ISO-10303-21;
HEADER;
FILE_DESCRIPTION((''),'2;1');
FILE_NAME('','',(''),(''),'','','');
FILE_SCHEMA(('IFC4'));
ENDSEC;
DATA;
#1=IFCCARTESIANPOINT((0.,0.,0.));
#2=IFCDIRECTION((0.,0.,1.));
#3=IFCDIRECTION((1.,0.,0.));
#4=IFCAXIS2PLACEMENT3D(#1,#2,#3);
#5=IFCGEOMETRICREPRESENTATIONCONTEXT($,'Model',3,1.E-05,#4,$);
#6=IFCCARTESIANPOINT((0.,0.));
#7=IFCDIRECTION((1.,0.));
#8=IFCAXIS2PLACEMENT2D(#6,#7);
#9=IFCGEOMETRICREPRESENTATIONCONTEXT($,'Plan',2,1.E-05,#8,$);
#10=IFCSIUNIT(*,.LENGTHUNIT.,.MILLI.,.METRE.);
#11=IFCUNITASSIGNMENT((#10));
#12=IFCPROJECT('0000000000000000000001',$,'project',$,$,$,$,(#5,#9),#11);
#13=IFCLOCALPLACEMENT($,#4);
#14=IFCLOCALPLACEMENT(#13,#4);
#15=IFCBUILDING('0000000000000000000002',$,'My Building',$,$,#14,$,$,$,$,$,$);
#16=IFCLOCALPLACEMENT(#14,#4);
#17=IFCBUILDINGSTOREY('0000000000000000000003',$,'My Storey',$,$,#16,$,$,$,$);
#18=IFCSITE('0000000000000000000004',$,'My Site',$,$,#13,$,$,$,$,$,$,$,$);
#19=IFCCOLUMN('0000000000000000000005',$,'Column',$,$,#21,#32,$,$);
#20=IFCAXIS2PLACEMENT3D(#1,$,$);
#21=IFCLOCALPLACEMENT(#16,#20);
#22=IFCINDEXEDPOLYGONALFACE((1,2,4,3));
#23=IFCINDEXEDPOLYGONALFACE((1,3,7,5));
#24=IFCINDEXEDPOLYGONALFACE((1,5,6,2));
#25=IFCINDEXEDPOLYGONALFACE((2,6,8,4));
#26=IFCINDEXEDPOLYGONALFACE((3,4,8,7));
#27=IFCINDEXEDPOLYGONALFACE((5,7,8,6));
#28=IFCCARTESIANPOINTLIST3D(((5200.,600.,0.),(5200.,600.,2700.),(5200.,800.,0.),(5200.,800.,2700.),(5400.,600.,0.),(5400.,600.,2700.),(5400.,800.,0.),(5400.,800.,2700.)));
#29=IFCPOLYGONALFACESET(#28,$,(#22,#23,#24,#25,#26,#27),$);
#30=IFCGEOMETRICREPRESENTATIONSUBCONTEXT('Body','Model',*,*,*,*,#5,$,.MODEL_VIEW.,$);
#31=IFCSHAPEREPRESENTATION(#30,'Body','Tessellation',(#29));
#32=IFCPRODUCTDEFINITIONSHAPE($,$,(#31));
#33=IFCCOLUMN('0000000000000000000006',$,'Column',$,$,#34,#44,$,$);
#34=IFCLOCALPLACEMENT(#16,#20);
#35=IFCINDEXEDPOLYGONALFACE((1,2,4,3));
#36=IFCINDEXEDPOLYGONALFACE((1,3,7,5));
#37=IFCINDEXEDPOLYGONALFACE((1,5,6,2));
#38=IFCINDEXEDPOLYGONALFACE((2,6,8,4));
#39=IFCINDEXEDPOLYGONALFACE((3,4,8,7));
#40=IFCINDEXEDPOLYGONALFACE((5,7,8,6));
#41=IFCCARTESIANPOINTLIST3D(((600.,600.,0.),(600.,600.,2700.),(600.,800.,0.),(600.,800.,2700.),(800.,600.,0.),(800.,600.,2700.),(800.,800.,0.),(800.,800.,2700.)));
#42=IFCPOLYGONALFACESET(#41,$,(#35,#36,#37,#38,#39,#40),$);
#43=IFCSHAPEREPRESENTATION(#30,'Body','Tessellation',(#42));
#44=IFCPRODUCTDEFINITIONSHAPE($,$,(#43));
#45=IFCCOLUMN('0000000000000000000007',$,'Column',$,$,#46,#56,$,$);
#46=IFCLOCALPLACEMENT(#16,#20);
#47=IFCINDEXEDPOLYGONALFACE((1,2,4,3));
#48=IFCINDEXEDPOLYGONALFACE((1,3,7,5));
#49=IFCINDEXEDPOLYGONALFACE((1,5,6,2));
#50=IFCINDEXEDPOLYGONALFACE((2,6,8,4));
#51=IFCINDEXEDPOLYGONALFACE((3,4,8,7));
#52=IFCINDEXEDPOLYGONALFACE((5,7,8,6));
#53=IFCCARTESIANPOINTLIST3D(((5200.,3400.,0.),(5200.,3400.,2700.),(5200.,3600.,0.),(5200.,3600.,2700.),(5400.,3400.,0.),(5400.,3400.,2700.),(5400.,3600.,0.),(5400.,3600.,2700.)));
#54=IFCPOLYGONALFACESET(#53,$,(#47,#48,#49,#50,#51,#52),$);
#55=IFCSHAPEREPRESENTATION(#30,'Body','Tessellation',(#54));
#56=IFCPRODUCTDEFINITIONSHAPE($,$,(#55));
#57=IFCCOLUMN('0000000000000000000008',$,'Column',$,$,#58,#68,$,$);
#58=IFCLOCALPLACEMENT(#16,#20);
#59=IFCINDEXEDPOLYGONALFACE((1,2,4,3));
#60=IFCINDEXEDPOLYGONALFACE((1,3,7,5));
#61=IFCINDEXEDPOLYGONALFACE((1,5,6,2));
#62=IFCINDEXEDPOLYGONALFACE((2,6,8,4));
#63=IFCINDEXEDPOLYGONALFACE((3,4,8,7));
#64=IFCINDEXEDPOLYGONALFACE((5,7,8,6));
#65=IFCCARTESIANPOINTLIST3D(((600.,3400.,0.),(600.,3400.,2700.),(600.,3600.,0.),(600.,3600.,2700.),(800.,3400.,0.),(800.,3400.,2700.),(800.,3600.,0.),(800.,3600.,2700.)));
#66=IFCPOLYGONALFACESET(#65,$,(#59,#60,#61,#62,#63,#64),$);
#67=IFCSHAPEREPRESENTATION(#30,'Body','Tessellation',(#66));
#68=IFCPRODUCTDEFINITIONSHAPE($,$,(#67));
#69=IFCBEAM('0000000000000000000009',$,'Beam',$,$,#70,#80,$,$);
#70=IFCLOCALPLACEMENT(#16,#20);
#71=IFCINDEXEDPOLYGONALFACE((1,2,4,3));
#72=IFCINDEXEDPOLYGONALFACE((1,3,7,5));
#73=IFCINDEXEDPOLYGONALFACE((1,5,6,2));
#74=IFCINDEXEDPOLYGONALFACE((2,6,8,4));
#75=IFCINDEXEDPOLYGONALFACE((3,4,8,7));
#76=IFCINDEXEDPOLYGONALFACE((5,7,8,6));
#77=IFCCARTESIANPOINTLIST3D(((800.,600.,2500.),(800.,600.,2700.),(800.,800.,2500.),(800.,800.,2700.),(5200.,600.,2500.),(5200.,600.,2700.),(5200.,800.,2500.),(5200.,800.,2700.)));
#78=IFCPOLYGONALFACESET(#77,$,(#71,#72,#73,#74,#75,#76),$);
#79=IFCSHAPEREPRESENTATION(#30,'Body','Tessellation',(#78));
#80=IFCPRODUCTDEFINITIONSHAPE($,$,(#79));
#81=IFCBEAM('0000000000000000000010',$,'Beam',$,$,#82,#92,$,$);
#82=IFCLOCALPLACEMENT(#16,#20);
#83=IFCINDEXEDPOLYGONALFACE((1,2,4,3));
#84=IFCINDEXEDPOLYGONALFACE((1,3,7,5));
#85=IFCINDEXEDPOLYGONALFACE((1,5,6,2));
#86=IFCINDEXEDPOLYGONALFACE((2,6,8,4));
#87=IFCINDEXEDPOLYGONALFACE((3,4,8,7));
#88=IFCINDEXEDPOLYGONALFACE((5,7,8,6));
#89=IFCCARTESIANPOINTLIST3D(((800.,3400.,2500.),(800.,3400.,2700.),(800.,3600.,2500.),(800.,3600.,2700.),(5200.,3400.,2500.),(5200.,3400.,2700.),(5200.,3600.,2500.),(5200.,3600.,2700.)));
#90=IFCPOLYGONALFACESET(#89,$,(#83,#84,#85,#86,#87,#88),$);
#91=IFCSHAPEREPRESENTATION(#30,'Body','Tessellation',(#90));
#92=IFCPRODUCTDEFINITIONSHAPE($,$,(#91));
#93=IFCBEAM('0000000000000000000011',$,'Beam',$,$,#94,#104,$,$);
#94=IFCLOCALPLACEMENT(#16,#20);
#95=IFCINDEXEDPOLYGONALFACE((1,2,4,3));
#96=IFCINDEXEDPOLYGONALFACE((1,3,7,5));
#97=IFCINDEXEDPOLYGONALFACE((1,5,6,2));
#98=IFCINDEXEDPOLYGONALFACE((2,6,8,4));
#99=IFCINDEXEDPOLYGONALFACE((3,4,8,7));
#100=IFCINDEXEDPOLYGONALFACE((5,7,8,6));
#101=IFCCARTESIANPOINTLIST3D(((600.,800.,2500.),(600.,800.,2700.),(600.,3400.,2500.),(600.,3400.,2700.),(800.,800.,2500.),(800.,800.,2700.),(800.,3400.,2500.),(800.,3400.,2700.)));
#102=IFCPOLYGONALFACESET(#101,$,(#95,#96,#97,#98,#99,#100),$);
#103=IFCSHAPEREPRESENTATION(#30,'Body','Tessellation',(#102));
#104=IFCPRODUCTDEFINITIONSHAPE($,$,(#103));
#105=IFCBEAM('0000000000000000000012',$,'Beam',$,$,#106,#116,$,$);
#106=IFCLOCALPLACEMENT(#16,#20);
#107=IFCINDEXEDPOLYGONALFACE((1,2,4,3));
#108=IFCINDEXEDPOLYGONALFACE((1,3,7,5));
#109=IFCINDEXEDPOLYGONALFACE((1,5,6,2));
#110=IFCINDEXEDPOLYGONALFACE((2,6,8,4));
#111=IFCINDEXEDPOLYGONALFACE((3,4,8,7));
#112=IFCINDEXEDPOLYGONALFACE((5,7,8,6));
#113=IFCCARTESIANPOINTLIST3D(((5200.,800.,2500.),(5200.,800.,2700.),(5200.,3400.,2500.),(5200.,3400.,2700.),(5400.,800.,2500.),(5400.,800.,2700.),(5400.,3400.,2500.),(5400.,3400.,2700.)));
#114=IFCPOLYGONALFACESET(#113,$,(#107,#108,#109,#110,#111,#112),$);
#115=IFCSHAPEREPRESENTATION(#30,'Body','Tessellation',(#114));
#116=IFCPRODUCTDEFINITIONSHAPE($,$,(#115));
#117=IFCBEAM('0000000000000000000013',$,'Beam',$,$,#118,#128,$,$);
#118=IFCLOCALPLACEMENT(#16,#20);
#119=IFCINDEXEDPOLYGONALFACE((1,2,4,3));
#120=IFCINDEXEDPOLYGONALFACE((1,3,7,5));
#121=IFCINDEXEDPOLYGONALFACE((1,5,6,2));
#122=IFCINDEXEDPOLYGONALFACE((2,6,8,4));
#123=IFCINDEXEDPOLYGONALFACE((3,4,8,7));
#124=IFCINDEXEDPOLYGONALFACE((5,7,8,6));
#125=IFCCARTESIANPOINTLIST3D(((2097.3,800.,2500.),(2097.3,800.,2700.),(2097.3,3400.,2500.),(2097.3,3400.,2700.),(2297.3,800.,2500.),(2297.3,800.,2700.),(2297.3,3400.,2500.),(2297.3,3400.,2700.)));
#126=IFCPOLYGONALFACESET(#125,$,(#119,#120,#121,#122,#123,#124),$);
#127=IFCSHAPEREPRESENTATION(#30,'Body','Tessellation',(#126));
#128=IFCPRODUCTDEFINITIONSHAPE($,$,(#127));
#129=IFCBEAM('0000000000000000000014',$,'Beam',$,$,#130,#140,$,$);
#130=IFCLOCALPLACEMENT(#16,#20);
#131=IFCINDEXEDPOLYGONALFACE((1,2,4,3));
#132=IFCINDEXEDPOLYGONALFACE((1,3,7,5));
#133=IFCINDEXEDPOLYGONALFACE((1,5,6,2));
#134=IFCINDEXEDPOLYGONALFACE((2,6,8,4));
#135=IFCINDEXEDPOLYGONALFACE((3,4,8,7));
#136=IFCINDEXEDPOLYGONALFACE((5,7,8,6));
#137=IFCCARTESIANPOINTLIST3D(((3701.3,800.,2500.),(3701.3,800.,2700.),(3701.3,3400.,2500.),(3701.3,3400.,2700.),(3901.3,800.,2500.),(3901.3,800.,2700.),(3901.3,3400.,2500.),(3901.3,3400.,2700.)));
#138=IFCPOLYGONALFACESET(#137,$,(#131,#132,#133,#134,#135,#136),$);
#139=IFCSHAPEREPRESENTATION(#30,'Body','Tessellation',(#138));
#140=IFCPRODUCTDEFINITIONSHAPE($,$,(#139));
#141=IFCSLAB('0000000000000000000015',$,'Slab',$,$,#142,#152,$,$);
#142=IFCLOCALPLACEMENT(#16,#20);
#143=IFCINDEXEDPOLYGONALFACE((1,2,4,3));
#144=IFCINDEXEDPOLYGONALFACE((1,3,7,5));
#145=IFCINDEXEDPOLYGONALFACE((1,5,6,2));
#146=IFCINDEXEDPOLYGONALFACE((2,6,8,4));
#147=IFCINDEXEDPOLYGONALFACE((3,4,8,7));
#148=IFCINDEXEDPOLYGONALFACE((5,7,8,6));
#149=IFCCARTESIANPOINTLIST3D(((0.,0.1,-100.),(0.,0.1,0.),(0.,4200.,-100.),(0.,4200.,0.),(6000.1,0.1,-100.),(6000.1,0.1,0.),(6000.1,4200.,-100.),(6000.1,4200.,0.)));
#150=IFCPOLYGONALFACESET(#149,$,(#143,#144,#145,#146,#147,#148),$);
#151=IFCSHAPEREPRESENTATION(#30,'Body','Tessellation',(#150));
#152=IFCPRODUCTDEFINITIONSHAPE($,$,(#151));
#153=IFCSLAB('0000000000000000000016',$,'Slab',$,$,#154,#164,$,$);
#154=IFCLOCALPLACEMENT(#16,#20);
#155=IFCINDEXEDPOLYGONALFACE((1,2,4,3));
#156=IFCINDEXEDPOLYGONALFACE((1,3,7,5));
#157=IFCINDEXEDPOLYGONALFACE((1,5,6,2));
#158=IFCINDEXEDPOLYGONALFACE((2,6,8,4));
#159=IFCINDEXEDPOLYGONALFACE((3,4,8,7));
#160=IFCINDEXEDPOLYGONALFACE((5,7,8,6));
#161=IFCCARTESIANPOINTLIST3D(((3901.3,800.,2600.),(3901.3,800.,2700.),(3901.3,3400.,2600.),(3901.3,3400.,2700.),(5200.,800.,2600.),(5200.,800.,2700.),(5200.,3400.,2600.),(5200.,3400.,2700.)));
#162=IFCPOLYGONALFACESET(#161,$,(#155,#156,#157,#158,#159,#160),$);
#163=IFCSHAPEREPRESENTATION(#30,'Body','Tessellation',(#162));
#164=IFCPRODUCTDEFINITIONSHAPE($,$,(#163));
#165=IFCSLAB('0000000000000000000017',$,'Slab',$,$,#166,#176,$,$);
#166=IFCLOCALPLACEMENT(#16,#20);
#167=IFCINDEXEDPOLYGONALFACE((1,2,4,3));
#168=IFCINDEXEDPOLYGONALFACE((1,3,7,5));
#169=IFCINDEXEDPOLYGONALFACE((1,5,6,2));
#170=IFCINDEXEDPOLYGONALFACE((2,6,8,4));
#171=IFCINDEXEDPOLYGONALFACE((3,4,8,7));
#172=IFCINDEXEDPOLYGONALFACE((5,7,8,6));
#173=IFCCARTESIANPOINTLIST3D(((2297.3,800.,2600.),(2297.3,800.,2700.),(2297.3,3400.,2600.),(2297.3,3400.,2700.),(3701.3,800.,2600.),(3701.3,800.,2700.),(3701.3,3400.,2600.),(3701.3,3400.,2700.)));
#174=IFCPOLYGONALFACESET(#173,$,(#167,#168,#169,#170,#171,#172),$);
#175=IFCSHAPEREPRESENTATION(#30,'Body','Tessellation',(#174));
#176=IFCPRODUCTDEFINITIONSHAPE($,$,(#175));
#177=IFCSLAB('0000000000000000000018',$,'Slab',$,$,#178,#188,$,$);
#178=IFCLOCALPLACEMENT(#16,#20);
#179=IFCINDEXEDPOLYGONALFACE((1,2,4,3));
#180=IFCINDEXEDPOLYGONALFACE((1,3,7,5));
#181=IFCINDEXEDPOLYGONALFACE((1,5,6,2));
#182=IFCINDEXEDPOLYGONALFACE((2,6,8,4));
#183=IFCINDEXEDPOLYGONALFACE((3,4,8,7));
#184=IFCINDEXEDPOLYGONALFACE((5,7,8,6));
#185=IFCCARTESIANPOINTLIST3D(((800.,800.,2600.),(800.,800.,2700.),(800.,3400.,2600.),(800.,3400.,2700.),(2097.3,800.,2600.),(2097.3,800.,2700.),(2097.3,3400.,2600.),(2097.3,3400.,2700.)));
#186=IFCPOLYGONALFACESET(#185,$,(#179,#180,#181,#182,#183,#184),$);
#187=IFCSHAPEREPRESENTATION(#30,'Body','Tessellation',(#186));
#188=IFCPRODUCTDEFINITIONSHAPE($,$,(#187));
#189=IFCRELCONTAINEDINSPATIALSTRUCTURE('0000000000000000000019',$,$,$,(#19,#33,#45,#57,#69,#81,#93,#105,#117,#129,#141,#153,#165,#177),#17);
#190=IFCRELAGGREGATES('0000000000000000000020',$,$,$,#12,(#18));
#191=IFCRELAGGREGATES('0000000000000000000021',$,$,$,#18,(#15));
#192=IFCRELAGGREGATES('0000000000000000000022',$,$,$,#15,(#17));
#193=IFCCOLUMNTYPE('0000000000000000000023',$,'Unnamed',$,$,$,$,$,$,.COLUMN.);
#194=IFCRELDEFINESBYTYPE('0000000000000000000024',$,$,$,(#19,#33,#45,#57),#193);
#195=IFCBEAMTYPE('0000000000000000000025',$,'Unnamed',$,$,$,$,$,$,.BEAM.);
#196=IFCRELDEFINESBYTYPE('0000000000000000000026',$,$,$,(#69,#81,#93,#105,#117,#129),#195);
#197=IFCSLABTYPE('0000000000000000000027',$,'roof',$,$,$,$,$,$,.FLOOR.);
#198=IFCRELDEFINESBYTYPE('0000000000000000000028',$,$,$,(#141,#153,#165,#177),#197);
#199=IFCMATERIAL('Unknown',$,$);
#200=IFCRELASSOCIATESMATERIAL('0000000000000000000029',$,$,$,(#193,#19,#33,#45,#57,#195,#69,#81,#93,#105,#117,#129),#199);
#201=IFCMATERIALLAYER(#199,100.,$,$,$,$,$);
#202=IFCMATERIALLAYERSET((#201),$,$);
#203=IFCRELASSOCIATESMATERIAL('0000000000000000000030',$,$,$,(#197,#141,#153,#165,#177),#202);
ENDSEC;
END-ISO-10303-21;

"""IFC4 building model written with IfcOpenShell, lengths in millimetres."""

from ifc_helpers import new_model, si_unit, frame, origin_with_axes, origin_2d_with_axis, place, context, subcontext, project, spatial, indexed_curve, rectangle, outline, extrude, material, layer, layer_set, layer_usage, material_profile, profile_set, profile_usage, type_object, element, save


model = new_model("IFC4")

# Units and contexts
model_context = context("Model", 3, precision=1e-05, world=origin_with_axes())
plan_context = context("Plan", 2, precision=1e-05, world=origin_2d_with_axis())
body_context_1 = subcontext(model_context, "Body", "Model", "MODEL_VIEW")
ifc_project = project(units=[si_unit("LENGTHUNIT", "METRE", prefix="MILLI")], contexts=[model_context, plan_context])

# Site, building, storey
site_placement = place(None, origin_with_axes())
site = spatial("IfcSite", under=ifc_project, at=site_placement, Name="My Site")
building_placement = place(site_placement, origin_with_axes())
building = spatial("IfcBuilding", under=site, at=building_placement, Name="My Building")
storey_placement = place(building_placement, origin_with_axes())
storey = spatial("IfcBuildingStorey", under=building, at=storey_placement, Name="My Storey")

# Columns
ifc_material = material(Name="Unknown")
ifc_material_profile_1 = material_profile(ifc_material, rectangle(XDim=200.0, YDim=200.0))
ifc_profile_set_1 = profile_set([ifc_material_profile_1])
ifc_profile_usage_1 = profile_usage(ifc_profile_set_1, cardinal=5)
column_type = type_object("IfcColumnType", Name="Unnamed", PredefinedType="COLUMN", material=ifc_profile_set_1)
column_1_placement = place(storey_placement, frame((5300.0, 700.0, 0.0), z_axis=(0.0, 0.0, 1.0), x_axis=(1.0, 0.0, 0.0)))
element("IfcColumn", 1, at=column_1_placement, inside=storey, type_object=column_type, material=ifc_profile_usage_1, Name="Column", context=body_context_1, shape_type="SweptSolid", body=[
    extrude(rectangle(XDim=200.0, YDim=200.0), origin_with_axes(), (0.0, 0.0, 1.0), 2700.0),
])
ifc_profile_usage_2 = profile_usage(ifc_profile_set_1, cardinal=5)
column_2_placement = place(storey_placement, frame((700.0, 700.0, 0.0), z_axis=(0.0, 0.0, 1.0), x_axis=(1.0, 0.0, 0.0)))
element("IfcColumn", 2, at=column_2_placement, inside=storey, type_object=column_type, material=ifc_profile_usage_2, Name="Column", context=body_context_1, shape_type="SweptSolid", body=[
    extrude(rectangle(XDim=200.0, YDim=200.0), origin_with_axes(), (0.0, 0.0, 1.0), 2700.0),
])
ifc_profile_usage_3 = profile_usage(ifc_profile_set_1, cardinal=5)
column_3_placement = place(storey_placement, frame((5300.0, 3500.0, 0.0), z_axis=(0.0, 0.0, 1.0), x_axis=(1.0, 0.0, 0.0)))
element("IfcColumn", 3, at=column_3_placement, inside=storey, type_object=column_type, material=ifc_profile_usage_3, Name="Column", context=body_context_1, shape_type="SweptSolid", body=[
    extrude(rectangle(XDim=200.0, YDim=200.0), origin_with_axes(), (0.0, 0.0, 1.0), 2700.0),
])
ifc_profile_usage_4 = profile_usage(ifc_profile_set_1, cardinal=5)
column_4_placement = place(storey_placement, frame((700.0, 3500.0, 0.0), z_axis=(0.0, 0.0, 1.0), x_axis=(1.0, 0.0, 0.0)))
element("IfcColumn", 4, at=column_4_placement, inside=storey, type_object=column_type, material=ifc_profile_usage_4, Name="Column", context=body_context_1, shape_type="SweptSolid", body=[
    extrude(rectangle(XDim=200.0, YDim=200.0), origin_with_axes(), (0.0, 0.0, 1.0), 2700.0),
])

# Beams
ifc_material_profile_2 = material_profile(ifc_material, rectangle(XDim=200.0, YDim=200.0))
ifc_profile_set_2 = profile_set([ifc_material_profile_2])
ifc_profile_usage_5 = profile_usage(ifc_profile_set_2, cardinal=5)
beam_type = type_object("IfcBeamType", Name="Unnamed", PredefinedType="BEAM", material=ifc_profile_set_2)
beam_1_placement = place(storey_placement, frame((800.0, 700.0, 2600.0), z_axis=(1.0, 0.0, 0.0), x_axis=(0.0, 1.0, 0.0)))
element("IfcBeam", 5, at=beam_1_placement, inside=storey, type_object=beam_type, material=ifc_profile_usage_5, Name="Beam", context=body_context_1, shape_type="SweptSolid", body=[
    extrude(rectangle(XDim=200.0, YDim=200.0), origin_with_axes(), (0.0, 0.0, 1.0), 4400.0),
])
ifc_profile_usage_6 = profile_usage(ifc_profile_set_2, cardinal=5)
beam_2_placement = place(storey_placement, frame((800.0, 3500.0, 2600.0), z_axis=(1.0, 0.0, 0.0), x_axis=(0.0, 1.0, 0.0)))
element("IfcBeam", 6, at=beam_2_placement, inside=storey, type_object=beam_type, material=ifc_profile_usage_6, Name="Beam", context=body_context_1, shape_type="SweptSolid", body=[
    extrude(rectangle(XDim=200.0, YDim=200.0), origin_with_axes(), (0.0, 0.0, 1.0), 4400.0),
])
ifc_profile_usage_7 = profile_usage(ifc_profile_set_2, cardinal=5)
beam_3_placement = place(storey_placement, frame((700.0, 3400.0, 2600.0), z_axis=(0.0, -1.0, 0.0), x_axis=(1.0, 0.0, 0.0)))
element("IfcBeam", 7, at=beam_3_placement, inside=storey, type_object=beam_type, material=ifc_profile_usage_7, Name="Beam", context=body_context_1, shape_type="SweptSolid", body=[
    extrude(rectangle(XDim=200.0, YDim=200.0), origin_with_axes(), (0.0, 0.0, 1.0), 2600.0),
])
ifc_profile_usage_8 = profile_usage(ifc_profile_set_2, cardinal=5)
beam_4_placement = place(storey_placement, frame((5300.0, 3400.0, 2600.0), z_axis=(0.0, -1.0, 0.0), x_axis=(1.0, 0.0, 0.0)))
element("IfcBeam", 8, at=beam_4_placement, inside=storey, type_object=beam_type, material=ifc_profile_usage_8, Name="Beam", context=body_context_1, shape_type="SweptSolid", body=[
    extrude(rectangle(XDim=200.0, YDim=200.0), origin_with_axes(), (0.0, 0.0, 1.0), 2600.0),
])
ifc_profile_usage_9 = profile_usage(ifc_profile_set_2, cardinal=5)
beam_5_placement = place(storey_placement, frame((2197.3, 3400.0, 2600.0), z_axis=(0.0, -1.0, 0.0), x_axis=(1.0, 0.0, 0.0)))
element("IfcBeam", 9, at=beam_5_placement, inside=storey, type_object=beam_type, material=ifc_profile_usage_9, Name="Beam", context=body_context_1, shape_type="SweptSolid", body=[
    extrude(rectangle(XDim=200.0, YDim=200.0), origin_with_axes(), (0.0, 0.0, 1.0), 2600.0),
])
ifc_profile_usage_10 = profile_usage(ifc_profile_set_2, cardinal=5)
beam_6_placement = place(storey_placement, frame((3801.3, 3400.0, 2600.0), z_axis=(0.0, -1.0, 0.0), x_axis=(1.0, 0.0, 0.0)))
element("IfcBeam", 10, at=beam_6_placement, inside=storey, type_object=beam_type, material=ifc_profile_usage_10, Name="Beam", context=body_context_1, shape_type="SweptSolid", body=[
    extrude(rectangle(XDim=200.0, YDim=200.0), origin_with_axes(), (0.0, 0.0, 1.0), 2600.0),
])

# Slabs
ifc_layer_1 = layer(ifc_material, 100.0)
ifc_layer_set_1 = layer_set([ifc_layer_1])
ifc_layer_usage_1 = layer_usage(ifc_layer_set_1, "AXIS3", "POSITIVE", -100.0)
slab_type = type_object("IfcSlabType", Name="roof", PredefinedType="FLOOR", material=ifc_layer_set_1)
slab_1_placement = place(storey_placement, frame((0.0, 4200.0, 0.0), z_axis=(0.0, 0.0, 1.0), x_axis=(1.0, 0.0, 0.0)))
element("IfcSlab", 11, at=slab_1_placement, inside=storey, type_object=slab_type, material=ifc_layer_usage_1, Name="Slab", context=body_context_1, shape_type="SweptSolid", body=[
    extrude(outline(indexed_curve([(0.0, 0.0), (6000.1, 0.0), (6000.1, -4199.9), (0.0, -4199.9), (0.0, 0.0)])), frame((0.0, 0.0, -100.0), z_axis=(0.0, 0.0, 1.0), x_axis=(1.0, 0.0, 0.0)), (0.0, 0.0, 1.0), 100.0),
])
ifc_layer_usage_2 = layer_usage(ifc_layer_set_1, "AXIS3", "POSITIVE", -100.0)
slab_2_placement = place(storey_placement, frame((5200.0, 800.0, 2700.0), z_axis=(0.0, 0.0, 1.0), x_axis=(1.0, 0.0, 0.0)))
element("IfcSlab", 12, at=slab_2_placement, inside=storey, type_object=slab_type, material=ifc_layer_usage_2, Name="Slab", context=body_context_1, shape_type="SweptSolid", body=[
    extrude(outline(indexed_curve([(0.0, 0.0), (0.0, 2600.0), (-1298.7, 2600.0), (-1298.7, 0.0), (0.0, 0.0)])), frame((0.0, 0.0, -100.0), z_axis=(0.0, 0.0, 1.0), x_axis=(1.0, 0.0, 0.0)), (0.0, 0.0, 1.0), 100.0),
])
ifc_layer_usage_3 = layer_usage(ifc_layer_set_1, "AXIS3", "POSITIVE", -100.0)
slab_3_placement = place(storey_placement, frame((3701.3, 3400.0, 2700.0), z_axis=(0.0, 0.0, 1.0), x_axis=(1.0, 0.0, 0.0)))
element("IfcSlab", 13, at=slab_3_placement, inside=storey, type_object=slab_type, material=ifc_layer_usage_3, Name="Slab", context=body_context_1, shape_type="SweptSolid", body=[
    extrude(outline(indexed_curve([(0.0, 0.0), (-1404.0, 0.0), (-1404.0, -2600.0), (0.0, -2600.0), (0.0, 0.0)])), frame((0.0, 0.0, -100.0), z_axis=(0.0, 0.0, 1.0), x_axis=(1.0, 0.0, 0.0)), (0.0, 0.0, 1.0), 100.0),
])
ifc_layer_usage_4 = layer_usage(ifc_layer_set_1, "AXIS3", "POSITIVE", -100.0)
slab_4_placement = place(storey_placement, frame((2097.3, 3400.0, 2700.0), z_axis=(0.0, 0.0, 1.0), x_axis=(1.0, 0.0, 0.0)))
element("IfcSlab", 14, at=slab_4_placement, inside=storey, type_object=slab_type, material=ifc_layer_usage_4, Name="Slab", context=body_context_1, shape_type="SweptSolid", body=[
    extrude(outline(indexed_curve([(0.0, 0.0), (-1297.3, 0.0), (-1297.3, -2600.0), (0.0, -2600.0), (0.0, 0.0)])), frame((0.0, 0.0, -100.0), z_axis=(0.0, 0.0, 1.0), x_axis=(1.0, 0.0, 0.0)), (0.0, 0.0, 1.0), 100.0),
])

save(model, "model.ifc")
